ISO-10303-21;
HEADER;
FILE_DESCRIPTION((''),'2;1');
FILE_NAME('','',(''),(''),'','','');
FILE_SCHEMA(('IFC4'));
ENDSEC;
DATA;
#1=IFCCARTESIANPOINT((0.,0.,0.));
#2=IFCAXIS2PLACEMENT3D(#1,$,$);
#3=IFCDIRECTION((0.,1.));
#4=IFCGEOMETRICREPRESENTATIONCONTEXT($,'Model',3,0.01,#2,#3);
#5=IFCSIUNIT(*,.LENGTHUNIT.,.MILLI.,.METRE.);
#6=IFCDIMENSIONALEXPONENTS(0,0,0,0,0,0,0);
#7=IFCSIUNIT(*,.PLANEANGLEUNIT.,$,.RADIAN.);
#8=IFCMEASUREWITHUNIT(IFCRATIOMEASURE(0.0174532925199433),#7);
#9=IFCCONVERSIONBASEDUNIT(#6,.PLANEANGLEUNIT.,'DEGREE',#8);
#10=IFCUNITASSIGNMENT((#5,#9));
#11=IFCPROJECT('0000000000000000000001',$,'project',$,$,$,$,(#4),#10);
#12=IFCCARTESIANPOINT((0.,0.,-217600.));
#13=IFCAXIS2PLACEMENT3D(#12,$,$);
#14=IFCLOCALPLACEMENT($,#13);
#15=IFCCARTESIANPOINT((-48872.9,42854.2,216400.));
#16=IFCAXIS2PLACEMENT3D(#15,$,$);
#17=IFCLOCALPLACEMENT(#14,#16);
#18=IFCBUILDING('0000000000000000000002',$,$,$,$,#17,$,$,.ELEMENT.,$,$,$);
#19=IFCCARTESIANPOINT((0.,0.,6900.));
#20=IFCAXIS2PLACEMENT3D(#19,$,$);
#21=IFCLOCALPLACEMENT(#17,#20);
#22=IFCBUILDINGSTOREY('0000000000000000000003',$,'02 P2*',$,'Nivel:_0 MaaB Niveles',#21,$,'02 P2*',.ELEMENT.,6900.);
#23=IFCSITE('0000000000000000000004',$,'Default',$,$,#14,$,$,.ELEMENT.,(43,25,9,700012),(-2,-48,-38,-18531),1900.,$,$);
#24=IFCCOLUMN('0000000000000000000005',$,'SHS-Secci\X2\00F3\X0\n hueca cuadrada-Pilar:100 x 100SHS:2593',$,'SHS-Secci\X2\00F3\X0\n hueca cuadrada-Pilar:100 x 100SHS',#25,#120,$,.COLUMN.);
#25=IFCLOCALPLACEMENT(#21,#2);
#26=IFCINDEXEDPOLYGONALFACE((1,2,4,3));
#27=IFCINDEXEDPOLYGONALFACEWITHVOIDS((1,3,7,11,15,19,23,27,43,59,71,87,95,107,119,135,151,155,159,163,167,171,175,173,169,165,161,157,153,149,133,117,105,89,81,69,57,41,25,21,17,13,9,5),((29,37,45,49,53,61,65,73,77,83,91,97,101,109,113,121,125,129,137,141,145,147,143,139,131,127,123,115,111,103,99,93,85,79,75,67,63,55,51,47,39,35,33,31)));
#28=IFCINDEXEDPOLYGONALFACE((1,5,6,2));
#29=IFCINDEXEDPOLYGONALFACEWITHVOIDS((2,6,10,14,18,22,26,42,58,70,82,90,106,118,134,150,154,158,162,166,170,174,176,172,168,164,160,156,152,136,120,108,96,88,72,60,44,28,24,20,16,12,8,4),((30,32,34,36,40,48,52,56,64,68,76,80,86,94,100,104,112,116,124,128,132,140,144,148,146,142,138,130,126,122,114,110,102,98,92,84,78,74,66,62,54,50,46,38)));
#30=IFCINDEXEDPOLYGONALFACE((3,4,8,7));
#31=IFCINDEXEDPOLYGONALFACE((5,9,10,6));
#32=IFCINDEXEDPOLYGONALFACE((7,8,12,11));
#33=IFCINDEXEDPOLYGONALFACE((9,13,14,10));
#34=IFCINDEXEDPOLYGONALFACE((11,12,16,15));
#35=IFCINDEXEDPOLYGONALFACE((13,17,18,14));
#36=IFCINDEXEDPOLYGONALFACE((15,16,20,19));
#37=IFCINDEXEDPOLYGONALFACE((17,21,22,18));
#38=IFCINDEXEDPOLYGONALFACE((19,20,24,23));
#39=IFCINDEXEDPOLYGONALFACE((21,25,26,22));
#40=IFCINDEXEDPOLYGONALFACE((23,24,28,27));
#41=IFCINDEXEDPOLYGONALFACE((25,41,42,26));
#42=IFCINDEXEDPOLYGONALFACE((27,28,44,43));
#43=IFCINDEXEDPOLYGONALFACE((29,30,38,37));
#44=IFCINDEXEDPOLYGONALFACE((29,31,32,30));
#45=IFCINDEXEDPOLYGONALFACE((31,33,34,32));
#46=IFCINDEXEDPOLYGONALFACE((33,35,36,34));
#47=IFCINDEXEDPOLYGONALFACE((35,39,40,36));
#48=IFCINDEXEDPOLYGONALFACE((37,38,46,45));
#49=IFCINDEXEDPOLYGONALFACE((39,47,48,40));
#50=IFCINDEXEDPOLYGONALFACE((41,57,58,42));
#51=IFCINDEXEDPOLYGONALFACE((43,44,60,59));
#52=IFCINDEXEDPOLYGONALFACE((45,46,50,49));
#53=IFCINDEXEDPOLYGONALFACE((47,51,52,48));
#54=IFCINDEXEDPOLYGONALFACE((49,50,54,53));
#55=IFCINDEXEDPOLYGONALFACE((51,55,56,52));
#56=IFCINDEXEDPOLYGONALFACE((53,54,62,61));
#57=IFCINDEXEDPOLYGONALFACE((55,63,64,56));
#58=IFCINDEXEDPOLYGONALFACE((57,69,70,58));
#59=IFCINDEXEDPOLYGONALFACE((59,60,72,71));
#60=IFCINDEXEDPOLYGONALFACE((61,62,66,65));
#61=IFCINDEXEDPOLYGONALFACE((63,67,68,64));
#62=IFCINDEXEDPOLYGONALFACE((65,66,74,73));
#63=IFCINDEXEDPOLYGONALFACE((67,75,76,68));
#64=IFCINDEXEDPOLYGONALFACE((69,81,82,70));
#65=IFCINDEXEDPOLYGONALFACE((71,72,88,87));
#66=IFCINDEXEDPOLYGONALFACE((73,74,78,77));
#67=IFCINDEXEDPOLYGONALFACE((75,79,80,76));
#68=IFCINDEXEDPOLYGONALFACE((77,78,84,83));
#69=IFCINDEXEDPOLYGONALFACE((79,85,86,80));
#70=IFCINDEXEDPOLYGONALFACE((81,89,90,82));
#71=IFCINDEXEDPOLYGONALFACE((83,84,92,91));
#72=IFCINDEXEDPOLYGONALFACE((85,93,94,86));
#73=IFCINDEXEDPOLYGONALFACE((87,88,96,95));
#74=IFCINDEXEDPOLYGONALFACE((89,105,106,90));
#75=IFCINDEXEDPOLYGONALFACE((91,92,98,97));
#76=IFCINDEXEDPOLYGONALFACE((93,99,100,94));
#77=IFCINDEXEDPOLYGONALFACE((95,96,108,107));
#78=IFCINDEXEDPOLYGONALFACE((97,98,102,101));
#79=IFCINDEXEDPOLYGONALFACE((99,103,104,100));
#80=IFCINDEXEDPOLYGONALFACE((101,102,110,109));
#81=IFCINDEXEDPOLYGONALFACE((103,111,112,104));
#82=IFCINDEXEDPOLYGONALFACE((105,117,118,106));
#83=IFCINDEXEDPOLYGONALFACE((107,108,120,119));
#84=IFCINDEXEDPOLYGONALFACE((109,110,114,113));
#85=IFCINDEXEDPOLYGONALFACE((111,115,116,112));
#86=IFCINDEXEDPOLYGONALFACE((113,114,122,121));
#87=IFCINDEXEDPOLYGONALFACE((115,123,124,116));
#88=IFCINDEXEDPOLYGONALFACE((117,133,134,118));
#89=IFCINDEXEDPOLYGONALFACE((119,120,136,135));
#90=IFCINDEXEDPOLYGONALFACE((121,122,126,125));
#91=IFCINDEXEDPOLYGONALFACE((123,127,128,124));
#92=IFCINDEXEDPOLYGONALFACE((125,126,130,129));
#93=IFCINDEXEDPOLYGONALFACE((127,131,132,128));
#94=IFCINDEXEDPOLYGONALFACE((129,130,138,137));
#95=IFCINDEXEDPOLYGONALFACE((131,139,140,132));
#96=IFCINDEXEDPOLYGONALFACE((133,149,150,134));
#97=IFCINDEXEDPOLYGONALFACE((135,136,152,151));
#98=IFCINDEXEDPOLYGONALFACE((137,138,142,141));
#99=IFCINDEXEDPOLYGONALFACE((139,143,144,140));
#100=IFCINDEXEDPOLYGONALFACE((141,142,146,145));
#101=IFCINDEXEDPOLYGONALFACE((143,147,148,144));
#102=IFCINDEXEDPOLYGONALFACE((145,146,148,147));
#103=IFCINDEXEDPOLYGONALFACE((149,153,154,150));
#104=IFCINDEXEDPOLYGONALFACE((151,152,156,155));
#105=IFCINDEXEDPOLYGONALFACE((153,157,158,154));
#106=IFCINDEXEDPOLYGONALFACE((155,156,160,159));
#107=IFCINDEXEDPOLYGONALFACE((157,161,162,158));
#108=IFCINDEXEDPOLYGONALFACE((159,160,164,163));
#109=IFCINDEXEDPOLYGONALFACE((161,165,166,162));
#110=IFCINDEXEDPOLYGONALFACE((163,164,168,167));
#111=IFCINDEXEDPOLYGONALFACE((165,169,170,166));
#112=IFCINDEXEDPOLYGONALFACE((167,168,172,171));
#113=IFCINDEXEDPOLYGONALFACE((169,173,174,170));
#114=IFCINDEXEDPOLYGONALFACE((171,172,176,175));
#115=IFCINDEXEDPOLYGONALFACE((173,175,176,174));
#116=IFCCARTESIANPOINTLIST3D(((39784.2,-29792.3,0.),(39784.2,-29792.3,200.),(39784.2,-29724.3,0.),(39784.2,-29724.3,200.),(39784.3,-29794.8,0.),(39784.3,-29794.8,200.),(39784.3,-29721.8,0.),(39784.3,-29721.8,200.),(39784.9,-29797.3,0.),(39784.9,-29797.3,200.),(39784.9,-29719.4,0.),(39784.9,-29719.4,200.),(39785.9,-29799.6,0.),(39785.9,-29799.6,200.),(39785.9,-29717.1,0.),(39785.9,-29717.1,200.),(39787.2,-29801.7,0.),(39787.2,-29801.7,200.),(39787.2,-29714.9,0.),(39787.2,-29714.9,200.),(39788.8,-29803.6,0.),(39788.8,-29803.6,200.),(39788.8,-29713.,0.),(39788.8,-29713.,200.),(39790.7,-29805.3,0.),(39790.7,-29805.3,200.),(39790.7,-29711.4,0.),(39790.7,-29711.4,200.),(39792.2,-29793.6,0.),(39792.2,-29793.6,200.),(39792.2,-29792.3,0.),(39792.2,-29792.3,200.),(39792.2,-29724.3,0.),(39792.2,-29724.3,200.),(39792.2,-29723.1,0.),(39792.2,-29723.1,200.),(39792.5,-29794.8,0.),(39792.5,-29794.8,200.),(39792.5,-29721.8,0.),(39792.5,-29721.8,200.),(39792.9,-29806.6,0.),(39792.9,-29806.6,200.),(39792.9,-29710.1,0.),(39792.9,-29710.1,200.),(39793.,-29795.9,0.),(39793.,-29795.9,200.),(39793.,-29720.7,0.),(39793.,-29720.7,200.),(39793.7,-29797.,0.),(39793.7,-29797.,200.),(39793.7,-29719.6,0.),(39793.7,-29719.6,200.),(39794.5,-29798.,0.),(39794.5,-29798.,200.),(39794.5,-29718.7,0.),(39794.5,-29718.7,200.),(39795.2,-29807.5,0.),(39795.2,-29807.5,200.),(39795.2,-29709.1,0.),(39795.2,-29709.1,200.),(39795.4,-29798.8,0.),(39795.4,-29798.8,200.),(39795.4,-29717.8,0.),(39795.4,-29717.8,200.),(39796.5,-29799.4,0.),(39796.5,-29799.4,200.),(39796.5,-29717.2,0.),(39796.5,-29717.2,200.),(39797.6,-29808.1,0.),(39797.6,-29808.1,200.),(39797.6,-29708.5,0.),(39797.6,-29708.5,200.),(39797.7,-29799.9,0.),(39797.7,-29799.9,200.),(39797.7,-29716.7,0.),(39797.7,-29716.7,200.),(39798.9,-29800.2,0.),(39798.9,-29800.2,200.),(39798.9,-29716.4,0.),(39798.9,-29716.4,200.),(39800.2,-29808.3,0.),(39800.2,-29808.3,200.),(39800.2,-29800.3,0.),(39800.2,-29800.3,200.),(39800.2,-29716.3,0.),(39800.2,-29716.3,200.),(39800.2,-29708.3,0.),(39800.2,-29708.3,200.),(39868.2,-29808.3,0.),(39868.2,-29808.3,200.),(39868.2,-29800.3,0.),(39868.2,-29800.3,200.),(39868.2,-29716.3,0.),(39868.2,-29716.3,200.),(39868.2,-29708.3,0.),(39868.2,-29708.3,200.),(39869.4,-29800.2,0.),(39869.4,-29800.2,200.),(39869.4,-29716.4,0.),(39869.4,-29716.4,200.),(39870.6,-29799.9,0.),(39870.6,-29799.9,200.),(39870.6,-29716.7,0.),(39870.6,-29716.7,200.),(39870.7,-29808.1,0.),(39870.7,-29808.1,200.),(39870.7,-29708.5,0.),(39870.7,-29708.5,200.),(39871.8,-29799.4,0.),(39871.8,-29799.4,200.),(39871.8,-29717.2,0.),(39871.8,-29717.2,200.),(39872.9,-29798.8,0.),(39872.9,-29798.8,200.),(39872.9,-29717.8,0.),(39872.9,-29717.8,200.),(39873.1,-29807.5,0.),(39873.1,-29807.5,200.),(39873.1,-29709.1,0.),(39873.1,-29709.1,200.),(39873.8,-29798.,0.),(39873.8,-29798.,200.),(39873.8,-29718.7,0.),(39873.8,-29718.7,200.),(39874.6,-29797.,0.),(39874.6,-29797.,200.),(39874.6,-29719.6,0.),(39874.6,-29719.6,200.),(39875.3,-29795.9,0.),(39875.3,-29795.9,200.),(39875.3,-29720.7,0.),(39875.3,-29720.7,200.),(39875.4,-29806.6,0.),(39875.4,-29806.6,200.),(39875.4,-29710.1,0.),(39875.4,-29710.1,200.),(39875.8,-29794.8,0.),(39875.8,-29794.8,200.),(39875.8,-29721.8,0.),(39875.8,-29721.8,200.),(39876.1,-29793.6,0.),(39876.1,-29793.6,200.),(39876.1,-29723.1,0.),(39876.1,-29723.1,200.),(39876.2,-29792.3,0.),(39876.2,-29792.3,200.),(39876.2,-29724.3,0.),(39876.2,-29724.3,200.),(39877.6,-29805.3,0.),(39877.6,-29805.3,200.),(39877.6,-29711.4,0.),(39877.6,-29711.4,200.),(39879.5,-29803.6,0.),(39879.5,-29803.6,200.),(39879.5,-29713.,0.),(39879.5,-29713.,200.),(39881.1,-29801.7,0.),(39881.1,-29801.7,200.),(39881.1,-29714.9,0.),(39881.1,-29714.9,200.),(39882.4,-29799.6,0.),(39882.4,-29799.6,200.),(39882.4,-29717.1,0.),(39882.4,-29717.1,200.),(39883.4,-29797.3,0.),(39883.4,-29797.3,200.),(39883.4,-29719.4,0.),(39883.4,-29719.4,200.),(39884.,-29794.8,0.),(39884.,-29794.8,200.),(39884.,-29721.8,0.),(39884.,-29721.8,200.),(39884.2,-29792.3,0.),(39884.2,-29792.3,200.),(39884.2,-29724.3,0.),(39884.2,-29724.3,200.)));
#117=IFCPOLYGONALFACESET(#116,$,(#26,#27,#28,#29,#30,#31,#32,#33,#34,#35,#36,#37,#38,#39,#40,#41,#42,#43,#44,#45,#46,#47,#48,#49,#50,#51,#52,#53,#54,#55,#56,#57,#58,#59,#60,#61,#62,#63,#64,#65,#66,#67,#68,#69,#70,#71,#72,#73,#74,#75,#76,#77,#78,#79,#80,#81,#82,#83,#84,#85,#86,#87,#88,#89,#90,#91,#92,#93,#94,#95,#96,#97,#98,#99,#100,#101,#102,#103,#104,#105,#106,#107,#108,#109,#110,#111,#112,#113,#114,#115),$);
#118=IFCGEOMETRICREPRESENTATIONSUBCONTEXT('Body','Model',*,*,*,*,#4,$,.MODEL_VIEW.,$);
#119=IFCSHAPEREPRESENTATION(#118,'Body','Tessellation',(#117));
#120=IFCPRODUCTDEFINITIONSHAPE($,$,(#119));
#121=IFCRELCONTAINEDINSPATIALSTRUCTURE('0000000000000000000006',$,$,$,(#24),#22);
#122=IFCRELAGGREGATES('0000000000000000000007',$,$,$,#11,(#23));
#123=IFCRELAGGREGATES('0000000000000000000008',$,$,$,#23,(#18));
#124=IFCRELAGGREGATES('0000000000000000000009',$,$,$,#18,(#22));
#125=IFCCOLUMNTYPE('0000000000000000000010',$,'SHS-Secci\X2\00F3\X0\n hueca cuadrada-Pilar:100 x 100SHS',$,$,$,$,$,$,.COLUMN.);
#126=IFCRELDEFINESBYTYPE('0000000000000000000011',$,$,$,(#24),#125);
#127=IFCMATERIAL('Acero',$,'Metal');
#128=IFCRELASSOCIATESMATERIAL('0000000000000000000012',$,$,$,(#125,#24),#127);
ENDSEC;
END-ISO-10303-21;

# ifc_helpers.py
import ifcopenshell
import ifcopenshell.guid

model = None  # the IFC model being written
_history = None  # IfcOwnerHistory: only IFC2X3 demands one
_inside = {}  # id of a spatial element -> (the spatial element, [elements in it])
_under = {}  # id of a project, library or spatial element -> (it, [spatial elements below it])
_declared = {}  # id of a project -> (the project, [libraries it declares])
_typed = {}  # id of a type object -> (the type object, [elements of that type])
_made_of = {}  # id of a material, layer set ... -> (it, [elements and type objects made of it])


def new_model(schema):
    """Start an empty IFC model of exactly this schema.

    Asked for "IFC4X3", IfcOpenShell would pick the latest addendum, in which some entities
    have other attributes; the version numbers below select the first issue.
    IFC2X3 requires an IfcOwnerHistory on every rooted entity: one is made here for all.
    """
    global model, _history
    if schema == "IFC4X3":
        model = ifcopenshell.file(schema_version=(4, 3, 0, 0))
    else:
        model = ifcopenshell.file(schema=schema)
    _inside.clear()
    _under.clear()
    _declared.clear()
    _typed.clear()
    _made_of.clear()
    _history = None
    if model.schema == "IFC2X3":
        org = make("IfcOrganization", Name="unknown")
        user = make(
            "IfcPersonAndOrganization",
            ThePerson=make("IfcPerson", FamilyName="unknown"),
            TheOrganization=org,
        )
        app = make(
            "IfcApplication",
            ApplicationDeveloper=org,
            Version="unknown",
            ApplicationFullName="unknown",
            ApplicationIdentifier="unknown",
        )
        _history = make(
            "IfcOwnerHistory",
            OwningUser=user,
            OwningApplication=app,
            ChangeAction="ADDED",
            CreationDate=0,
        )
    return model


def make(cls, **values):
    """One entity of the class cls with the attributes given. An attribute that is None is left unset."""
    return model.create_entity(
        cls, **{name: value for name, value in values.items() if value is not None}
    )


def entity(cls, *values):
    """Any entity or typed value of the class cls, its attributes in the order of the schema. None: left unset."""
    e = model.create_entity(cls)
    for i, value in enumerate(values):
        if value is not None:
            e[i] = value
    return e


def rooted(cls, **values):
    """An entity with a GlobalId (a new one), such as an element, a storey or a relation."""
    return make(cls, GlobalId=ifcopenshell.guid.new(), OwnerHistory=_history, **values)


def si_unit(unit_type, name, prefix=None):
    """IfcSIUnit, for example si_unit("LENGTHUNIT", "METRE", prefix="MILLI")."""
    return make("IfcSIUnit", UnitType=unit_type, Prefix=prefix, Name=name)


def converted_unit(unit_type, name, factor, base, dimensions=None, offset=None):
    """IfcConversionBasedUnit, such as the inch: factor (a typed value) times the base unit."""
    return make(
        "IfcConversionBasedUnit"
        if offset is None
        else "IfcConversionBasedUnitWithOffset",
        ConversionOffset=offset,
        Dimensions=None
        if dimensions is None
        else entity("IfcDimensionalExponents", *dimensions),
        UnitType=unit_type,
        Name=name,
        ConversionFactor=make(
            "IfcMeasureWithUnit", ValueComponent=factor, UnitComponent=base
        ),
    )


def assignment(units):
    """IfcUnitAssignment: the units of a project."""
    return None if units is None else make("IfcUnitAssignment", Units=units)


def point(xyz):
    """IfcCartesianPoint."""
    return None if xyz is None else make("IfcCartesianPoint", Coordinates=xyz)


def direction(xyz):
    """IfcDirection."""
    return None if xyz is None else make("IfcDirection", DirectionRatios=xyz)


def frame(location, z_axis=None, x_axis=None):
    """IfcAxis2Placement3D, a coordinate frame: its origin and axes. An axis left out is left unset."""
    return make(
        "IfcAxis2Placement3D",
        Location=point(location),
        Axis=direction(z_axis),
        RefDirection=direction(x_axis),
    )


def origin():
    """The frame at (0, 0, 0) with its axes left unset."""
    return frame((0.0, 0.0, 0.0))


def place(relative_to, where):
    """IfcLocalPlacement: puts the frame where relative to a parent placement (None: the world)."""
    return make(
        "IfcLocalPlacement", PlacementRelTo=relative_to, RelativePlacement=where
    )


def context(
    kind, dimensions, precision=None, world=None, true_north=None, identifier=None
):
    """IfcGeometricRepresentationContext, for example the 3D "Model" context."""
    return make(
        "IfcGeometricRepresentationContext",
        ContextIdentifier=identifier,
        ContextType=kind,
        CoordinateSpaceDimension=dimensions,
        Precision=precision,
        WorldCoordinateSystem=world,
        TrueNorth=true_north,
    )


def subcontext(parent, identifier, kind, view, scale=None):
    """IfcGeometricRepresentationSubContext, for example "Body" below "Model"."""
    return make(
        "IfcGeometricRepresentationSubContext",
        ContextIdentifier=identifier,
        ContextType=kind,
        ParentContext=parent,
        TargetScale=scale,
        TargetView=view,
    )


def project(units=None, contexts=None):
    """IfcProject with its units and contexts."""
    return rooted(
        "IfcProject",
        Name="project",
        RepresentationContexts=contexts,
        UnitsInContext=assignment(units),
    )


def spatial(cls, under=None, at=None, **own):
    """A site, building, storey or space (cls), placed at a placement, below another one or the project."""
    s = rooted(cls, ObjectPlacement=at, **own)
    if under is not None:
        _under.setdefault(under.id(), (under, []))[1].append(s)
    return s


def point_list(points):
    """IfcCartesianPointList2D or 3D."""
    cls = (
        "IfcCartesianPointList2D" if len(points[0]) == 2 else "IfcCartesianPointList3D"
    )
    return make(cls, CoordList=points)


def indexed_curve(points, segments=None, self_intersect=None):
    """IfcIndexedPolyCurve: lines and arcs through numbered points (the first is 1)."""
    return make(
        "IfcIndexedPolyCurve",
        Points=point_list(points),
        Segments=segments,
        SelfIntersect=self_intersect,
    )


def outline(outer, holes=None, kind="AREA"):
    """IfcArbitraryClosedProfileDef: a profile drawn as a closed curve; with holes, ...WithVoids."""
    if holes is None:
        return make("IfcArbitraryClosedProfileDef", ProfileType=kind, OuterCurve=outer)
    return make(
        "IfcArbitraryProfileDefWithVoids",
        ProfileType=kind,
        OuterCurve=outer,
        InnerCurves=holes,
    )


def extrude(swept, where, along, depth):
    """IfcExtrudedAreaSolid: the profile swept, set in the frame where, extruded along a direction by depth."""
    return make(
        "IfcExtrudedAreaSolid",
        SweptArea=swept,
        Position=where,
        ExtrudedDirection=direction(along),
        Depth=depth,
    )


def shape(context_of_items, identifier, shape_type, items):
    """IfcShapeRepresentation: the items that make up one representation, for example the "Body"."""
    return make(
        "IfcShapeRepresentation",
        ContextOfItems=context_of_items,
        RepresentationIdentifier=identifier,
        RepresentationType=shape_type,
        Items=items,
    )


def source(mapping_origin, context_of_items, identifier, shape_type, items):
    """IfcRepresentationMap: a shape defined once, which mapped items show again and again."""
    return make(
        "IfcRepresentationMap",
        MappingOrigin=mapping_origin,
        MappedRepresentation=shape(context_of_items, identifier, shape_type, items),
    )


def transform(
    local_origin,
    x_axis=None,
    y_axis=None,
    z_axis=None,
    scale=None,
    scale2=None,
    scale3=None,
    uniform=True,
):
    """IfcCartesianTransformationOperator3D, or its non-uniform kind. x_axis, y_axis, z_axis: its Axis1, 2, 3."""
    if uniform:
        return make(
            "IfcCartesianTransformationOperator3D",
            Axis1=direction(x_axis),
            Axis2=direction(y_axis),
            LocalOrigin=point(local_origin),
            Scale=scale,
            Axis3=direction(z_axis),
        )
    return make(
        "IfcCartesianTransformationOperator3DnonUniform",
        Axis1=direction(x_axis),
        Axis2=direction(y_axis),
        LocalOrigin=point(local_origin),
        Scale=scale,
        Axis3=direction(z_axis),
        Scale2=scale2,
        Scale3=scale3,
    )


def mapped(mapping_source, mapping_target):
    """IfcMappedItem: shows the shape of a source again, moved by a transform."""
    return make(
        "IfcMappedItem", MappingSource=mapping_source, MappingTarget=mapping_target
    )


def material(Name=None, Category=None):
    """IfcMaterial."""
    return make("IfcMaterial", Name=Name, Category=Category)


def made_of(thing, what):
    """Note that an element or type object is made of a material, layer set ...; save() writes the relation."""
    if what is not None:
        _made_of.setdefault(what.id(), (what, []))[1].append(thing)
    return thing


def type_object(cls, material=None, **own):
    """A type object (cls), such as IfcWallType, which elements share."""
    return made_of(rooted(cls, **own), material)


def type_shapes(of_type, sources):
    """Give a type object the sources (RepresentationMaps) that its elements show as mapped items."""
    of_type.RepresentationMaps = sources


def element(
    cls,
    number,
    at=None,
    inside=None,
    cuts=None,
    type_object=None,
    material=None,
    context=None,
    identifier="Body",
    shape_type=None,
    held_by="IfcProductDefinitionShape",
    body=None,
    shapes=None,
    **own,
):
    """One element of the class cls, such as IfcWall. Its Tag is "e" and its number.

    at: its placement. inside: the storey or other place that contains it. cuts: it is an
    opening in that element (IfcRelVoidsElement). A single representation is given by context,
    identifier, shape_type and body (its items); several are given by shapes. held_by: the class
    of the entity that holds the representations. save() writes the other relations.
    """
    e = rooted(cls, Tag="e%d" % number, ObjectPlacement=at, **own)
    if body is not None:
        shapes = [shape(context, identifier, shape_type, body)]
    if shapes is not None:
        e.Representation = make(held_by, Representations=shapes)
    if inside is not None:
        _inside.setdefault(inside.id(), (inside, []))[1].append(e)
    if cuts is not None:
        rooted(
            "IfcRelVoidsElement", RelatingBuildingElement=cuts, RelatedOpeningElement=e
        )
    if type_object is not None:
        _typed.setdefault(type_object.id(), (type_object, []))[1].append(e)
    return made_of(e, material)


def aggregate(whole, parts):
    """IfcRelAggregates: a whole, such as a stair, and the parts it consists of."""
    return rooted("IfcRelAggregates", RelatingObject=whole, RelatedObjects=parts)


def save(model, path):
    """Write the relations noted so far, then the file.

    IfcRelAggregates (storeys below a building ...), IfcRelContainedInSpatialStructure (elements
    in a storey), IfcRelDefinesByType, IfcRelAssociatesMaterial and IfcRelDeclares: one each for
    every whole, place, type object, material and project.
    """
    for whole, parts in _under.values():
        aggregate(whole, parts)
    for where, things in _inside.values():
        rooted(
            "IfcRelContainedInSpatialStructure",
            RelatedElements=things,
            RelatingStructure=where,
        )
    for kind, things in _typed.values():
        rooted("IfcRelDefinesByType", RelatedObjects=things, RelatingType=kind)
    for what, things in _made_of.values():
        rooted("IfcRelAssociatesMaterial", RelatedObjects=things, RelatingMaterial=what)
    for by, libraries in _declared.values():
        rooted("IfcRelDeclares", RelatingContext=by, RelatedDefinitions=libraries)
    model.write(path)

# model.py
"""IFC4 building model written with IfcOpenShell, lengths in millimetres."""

from ifc_helpers import new_model, entity, si_unit, converted_unit, direction, frame, origin, place, context, subcontext, project, spatial, indexed_curve, outline, extrude, source, transform, mapped, material, type_object, type_shapes, element, save


model = new_model("IFC4")

# Units and contexts
model_context = context("Model", 3, precision=0.01, world=origin(), true_north=direction((0.0, 1.0)))
body_context = subcontext(model_context, "Body", "Model", "MODEL_VIEW")
ifc_project = project(units=[si_unit("LENGTHUNIT", "METRE", prefix="MILLI"), converted_unit("PLANEANGLEUNIT", "DEGREE", entity("IfcRatioMeasure", 0.0174532925199433), si_unit("PLANEANGLEUNIT", "RADIAN"), dimensions=[0, 0, 0, 0, 0, 0, 0])], contexts=[model_context])

# Site, building, storey
site_placement = place(None, frame((0.0, 0.0, -217600.0)))
site = spatial("IfcSite", under=ifc_project, at=site_placement, Name="Default", CompositionType="ELEMENT", RefLatitude=(43, 25, 9, 700012), RefLongitude=(-2, -48, -38, -18531), RefElevation=1900.0)
building_placement = place(site_placement, frame((-48872.9, 42854.2, 216400.0)))
building = spatial("IfcBuilding", under=site, at=building_placement, CompositionType="ELEMENT")
storey_placement = place(building_placement, frame((0.0, 0.0, 6900.0)))
storey = spatial("IfcBuildingStorey", under=building, at=storey_placement, Name="02 P2*", ObjectType="Nivel:_0 MaaB Niveles", LongName="02 P2*", CompositionType="ELEMENT", Elevation=6900.0)

# Column
ifc_material_1 = material(Name="Acero", Category="Metal")
column_type_1 = type_object("IfcColumnType", Name="SHS-Sección hueca cuadrada-Pilar:100 x 100SHS", PredefinedType="COLUMN", material=ifc_material_1)
shared_shape_1 = source(origin(), body_context, "Body", "SweptSolid", [
    extrude(outline(indexed_curve([(-34.0, -50.0), (34.0, -50.0), (36.5, -49.8), (38.9, -49.2), (41.3, -48.3), (43.4, -46.9), (45.3, -45.3), (46.9, -43.4), (48.3, -41.3), (49.2, -38.9), (49.8, -36.5), (50.0, -34.0), (50.0, 34.0), (49.8, 36.5), (49.2, 38.9), (48.3, 41.3), (46.9, 43.4), (45.3, 45.3), (43.4, 46.9), (41.3, 48.3), (38.9, 49.2), (36.5, 49.8), (34.0, 50.0), (-34.0, 50.0), (-36.5, 49.8), (-38.9, 49.2), (-41.3, 48.3), (-43.4, 46.9), (-45.3, 45.3), (-46.9, 43.4), (-48.3, 41.3), (-49.2, 38.9), (-49.8, 36.5), (-50.0, 34.0), (-50.0, -34.0), (-49.8, -36.5), (-49.2, -38.9), (-48.3, -41.3), (-46.9, -43.4), (-45.3, -45.3), (-43.4, -46.9), (-41.3, -48.3), (-38.9, -49.2), (-36.5, -49.8), (-34.0, -50.0)], self_intersect=False), holes=[indexed_curve([(-34.0, -42.0), (-35.3, -41.9), (-36.5, -41.6), (-37.6, -41.1), (-38.7, -40.5), (-39.7, -39.7), (-40.5, -38.7), (-41.1, -37.6), (-41.6, -36.5), (-41.9, -35.3), (-42.0, -34.0), (-42.0, 34.0), (-41.9, 35.3), (-41.6, 36.5), (-41.1, 37.6), (-40.5, 38.7), (-39.7, 39.7), (-38.7, 40.5), (-37.6, 41.1), (-36.5, 41.6), (-35.3, 41.9), (-34.0, 42.0), (34.0, 42.0), (35.3, 41.9), (36.5, 41.6), (37.6, 41.1), (38.7, 40.5), (39.7, 39.7), (40.5, 38.7), (41.1, 37.6), (41.6, 36.5), (41.9, 35.3), (42.0, 34.0), (42.0, -34.0), (41.9, -35.3), (41.6, -36.5), (41.1, -37.6), (40.5, -38.7), (39.7, -39.7), (38.7, -40.5), (37.6, -41.1), (36.5, -41.6), (35.3, -41.9), (34.0, -42.0), (-34.0, -42.0)], self_intersect=False)]), frame((0.0, 0.0, 6900.0), z_axis=(0.0, 0.0, 1.0), x_axis=(-1.0, 0.0, 0.0)), (0.0, 0.0, 1.0), 200.0),
])
type_shapes(column_type_1, [shared_shape_1])
column_1_placement = place(storey_placement, frame((39834.2, -29758.3, -6900.0), z_axis=(0.0, 0.0, 1.0), x_axis=(0.0, -1.0, 0.0)))
element("IfcColumn", 1, at=column_1_placement, inside=storey, type_object=column_type_1, material=ifc_material_1, Name="SHS-Sección hueca cuadrada-Pilar:100 x 100SHS:2593", ObjectType="SHS-Sección hueca cuadrada-Pilar:100 x 100SHS", PredefinedType="COLUMN", context=body_context, shape_type="MappedRepresentation", body=[
    mapped(shared_shape_1, transform((0.0, 0.0, 0.0), scale=1.0)),
])

save(model, "model.ifc")
